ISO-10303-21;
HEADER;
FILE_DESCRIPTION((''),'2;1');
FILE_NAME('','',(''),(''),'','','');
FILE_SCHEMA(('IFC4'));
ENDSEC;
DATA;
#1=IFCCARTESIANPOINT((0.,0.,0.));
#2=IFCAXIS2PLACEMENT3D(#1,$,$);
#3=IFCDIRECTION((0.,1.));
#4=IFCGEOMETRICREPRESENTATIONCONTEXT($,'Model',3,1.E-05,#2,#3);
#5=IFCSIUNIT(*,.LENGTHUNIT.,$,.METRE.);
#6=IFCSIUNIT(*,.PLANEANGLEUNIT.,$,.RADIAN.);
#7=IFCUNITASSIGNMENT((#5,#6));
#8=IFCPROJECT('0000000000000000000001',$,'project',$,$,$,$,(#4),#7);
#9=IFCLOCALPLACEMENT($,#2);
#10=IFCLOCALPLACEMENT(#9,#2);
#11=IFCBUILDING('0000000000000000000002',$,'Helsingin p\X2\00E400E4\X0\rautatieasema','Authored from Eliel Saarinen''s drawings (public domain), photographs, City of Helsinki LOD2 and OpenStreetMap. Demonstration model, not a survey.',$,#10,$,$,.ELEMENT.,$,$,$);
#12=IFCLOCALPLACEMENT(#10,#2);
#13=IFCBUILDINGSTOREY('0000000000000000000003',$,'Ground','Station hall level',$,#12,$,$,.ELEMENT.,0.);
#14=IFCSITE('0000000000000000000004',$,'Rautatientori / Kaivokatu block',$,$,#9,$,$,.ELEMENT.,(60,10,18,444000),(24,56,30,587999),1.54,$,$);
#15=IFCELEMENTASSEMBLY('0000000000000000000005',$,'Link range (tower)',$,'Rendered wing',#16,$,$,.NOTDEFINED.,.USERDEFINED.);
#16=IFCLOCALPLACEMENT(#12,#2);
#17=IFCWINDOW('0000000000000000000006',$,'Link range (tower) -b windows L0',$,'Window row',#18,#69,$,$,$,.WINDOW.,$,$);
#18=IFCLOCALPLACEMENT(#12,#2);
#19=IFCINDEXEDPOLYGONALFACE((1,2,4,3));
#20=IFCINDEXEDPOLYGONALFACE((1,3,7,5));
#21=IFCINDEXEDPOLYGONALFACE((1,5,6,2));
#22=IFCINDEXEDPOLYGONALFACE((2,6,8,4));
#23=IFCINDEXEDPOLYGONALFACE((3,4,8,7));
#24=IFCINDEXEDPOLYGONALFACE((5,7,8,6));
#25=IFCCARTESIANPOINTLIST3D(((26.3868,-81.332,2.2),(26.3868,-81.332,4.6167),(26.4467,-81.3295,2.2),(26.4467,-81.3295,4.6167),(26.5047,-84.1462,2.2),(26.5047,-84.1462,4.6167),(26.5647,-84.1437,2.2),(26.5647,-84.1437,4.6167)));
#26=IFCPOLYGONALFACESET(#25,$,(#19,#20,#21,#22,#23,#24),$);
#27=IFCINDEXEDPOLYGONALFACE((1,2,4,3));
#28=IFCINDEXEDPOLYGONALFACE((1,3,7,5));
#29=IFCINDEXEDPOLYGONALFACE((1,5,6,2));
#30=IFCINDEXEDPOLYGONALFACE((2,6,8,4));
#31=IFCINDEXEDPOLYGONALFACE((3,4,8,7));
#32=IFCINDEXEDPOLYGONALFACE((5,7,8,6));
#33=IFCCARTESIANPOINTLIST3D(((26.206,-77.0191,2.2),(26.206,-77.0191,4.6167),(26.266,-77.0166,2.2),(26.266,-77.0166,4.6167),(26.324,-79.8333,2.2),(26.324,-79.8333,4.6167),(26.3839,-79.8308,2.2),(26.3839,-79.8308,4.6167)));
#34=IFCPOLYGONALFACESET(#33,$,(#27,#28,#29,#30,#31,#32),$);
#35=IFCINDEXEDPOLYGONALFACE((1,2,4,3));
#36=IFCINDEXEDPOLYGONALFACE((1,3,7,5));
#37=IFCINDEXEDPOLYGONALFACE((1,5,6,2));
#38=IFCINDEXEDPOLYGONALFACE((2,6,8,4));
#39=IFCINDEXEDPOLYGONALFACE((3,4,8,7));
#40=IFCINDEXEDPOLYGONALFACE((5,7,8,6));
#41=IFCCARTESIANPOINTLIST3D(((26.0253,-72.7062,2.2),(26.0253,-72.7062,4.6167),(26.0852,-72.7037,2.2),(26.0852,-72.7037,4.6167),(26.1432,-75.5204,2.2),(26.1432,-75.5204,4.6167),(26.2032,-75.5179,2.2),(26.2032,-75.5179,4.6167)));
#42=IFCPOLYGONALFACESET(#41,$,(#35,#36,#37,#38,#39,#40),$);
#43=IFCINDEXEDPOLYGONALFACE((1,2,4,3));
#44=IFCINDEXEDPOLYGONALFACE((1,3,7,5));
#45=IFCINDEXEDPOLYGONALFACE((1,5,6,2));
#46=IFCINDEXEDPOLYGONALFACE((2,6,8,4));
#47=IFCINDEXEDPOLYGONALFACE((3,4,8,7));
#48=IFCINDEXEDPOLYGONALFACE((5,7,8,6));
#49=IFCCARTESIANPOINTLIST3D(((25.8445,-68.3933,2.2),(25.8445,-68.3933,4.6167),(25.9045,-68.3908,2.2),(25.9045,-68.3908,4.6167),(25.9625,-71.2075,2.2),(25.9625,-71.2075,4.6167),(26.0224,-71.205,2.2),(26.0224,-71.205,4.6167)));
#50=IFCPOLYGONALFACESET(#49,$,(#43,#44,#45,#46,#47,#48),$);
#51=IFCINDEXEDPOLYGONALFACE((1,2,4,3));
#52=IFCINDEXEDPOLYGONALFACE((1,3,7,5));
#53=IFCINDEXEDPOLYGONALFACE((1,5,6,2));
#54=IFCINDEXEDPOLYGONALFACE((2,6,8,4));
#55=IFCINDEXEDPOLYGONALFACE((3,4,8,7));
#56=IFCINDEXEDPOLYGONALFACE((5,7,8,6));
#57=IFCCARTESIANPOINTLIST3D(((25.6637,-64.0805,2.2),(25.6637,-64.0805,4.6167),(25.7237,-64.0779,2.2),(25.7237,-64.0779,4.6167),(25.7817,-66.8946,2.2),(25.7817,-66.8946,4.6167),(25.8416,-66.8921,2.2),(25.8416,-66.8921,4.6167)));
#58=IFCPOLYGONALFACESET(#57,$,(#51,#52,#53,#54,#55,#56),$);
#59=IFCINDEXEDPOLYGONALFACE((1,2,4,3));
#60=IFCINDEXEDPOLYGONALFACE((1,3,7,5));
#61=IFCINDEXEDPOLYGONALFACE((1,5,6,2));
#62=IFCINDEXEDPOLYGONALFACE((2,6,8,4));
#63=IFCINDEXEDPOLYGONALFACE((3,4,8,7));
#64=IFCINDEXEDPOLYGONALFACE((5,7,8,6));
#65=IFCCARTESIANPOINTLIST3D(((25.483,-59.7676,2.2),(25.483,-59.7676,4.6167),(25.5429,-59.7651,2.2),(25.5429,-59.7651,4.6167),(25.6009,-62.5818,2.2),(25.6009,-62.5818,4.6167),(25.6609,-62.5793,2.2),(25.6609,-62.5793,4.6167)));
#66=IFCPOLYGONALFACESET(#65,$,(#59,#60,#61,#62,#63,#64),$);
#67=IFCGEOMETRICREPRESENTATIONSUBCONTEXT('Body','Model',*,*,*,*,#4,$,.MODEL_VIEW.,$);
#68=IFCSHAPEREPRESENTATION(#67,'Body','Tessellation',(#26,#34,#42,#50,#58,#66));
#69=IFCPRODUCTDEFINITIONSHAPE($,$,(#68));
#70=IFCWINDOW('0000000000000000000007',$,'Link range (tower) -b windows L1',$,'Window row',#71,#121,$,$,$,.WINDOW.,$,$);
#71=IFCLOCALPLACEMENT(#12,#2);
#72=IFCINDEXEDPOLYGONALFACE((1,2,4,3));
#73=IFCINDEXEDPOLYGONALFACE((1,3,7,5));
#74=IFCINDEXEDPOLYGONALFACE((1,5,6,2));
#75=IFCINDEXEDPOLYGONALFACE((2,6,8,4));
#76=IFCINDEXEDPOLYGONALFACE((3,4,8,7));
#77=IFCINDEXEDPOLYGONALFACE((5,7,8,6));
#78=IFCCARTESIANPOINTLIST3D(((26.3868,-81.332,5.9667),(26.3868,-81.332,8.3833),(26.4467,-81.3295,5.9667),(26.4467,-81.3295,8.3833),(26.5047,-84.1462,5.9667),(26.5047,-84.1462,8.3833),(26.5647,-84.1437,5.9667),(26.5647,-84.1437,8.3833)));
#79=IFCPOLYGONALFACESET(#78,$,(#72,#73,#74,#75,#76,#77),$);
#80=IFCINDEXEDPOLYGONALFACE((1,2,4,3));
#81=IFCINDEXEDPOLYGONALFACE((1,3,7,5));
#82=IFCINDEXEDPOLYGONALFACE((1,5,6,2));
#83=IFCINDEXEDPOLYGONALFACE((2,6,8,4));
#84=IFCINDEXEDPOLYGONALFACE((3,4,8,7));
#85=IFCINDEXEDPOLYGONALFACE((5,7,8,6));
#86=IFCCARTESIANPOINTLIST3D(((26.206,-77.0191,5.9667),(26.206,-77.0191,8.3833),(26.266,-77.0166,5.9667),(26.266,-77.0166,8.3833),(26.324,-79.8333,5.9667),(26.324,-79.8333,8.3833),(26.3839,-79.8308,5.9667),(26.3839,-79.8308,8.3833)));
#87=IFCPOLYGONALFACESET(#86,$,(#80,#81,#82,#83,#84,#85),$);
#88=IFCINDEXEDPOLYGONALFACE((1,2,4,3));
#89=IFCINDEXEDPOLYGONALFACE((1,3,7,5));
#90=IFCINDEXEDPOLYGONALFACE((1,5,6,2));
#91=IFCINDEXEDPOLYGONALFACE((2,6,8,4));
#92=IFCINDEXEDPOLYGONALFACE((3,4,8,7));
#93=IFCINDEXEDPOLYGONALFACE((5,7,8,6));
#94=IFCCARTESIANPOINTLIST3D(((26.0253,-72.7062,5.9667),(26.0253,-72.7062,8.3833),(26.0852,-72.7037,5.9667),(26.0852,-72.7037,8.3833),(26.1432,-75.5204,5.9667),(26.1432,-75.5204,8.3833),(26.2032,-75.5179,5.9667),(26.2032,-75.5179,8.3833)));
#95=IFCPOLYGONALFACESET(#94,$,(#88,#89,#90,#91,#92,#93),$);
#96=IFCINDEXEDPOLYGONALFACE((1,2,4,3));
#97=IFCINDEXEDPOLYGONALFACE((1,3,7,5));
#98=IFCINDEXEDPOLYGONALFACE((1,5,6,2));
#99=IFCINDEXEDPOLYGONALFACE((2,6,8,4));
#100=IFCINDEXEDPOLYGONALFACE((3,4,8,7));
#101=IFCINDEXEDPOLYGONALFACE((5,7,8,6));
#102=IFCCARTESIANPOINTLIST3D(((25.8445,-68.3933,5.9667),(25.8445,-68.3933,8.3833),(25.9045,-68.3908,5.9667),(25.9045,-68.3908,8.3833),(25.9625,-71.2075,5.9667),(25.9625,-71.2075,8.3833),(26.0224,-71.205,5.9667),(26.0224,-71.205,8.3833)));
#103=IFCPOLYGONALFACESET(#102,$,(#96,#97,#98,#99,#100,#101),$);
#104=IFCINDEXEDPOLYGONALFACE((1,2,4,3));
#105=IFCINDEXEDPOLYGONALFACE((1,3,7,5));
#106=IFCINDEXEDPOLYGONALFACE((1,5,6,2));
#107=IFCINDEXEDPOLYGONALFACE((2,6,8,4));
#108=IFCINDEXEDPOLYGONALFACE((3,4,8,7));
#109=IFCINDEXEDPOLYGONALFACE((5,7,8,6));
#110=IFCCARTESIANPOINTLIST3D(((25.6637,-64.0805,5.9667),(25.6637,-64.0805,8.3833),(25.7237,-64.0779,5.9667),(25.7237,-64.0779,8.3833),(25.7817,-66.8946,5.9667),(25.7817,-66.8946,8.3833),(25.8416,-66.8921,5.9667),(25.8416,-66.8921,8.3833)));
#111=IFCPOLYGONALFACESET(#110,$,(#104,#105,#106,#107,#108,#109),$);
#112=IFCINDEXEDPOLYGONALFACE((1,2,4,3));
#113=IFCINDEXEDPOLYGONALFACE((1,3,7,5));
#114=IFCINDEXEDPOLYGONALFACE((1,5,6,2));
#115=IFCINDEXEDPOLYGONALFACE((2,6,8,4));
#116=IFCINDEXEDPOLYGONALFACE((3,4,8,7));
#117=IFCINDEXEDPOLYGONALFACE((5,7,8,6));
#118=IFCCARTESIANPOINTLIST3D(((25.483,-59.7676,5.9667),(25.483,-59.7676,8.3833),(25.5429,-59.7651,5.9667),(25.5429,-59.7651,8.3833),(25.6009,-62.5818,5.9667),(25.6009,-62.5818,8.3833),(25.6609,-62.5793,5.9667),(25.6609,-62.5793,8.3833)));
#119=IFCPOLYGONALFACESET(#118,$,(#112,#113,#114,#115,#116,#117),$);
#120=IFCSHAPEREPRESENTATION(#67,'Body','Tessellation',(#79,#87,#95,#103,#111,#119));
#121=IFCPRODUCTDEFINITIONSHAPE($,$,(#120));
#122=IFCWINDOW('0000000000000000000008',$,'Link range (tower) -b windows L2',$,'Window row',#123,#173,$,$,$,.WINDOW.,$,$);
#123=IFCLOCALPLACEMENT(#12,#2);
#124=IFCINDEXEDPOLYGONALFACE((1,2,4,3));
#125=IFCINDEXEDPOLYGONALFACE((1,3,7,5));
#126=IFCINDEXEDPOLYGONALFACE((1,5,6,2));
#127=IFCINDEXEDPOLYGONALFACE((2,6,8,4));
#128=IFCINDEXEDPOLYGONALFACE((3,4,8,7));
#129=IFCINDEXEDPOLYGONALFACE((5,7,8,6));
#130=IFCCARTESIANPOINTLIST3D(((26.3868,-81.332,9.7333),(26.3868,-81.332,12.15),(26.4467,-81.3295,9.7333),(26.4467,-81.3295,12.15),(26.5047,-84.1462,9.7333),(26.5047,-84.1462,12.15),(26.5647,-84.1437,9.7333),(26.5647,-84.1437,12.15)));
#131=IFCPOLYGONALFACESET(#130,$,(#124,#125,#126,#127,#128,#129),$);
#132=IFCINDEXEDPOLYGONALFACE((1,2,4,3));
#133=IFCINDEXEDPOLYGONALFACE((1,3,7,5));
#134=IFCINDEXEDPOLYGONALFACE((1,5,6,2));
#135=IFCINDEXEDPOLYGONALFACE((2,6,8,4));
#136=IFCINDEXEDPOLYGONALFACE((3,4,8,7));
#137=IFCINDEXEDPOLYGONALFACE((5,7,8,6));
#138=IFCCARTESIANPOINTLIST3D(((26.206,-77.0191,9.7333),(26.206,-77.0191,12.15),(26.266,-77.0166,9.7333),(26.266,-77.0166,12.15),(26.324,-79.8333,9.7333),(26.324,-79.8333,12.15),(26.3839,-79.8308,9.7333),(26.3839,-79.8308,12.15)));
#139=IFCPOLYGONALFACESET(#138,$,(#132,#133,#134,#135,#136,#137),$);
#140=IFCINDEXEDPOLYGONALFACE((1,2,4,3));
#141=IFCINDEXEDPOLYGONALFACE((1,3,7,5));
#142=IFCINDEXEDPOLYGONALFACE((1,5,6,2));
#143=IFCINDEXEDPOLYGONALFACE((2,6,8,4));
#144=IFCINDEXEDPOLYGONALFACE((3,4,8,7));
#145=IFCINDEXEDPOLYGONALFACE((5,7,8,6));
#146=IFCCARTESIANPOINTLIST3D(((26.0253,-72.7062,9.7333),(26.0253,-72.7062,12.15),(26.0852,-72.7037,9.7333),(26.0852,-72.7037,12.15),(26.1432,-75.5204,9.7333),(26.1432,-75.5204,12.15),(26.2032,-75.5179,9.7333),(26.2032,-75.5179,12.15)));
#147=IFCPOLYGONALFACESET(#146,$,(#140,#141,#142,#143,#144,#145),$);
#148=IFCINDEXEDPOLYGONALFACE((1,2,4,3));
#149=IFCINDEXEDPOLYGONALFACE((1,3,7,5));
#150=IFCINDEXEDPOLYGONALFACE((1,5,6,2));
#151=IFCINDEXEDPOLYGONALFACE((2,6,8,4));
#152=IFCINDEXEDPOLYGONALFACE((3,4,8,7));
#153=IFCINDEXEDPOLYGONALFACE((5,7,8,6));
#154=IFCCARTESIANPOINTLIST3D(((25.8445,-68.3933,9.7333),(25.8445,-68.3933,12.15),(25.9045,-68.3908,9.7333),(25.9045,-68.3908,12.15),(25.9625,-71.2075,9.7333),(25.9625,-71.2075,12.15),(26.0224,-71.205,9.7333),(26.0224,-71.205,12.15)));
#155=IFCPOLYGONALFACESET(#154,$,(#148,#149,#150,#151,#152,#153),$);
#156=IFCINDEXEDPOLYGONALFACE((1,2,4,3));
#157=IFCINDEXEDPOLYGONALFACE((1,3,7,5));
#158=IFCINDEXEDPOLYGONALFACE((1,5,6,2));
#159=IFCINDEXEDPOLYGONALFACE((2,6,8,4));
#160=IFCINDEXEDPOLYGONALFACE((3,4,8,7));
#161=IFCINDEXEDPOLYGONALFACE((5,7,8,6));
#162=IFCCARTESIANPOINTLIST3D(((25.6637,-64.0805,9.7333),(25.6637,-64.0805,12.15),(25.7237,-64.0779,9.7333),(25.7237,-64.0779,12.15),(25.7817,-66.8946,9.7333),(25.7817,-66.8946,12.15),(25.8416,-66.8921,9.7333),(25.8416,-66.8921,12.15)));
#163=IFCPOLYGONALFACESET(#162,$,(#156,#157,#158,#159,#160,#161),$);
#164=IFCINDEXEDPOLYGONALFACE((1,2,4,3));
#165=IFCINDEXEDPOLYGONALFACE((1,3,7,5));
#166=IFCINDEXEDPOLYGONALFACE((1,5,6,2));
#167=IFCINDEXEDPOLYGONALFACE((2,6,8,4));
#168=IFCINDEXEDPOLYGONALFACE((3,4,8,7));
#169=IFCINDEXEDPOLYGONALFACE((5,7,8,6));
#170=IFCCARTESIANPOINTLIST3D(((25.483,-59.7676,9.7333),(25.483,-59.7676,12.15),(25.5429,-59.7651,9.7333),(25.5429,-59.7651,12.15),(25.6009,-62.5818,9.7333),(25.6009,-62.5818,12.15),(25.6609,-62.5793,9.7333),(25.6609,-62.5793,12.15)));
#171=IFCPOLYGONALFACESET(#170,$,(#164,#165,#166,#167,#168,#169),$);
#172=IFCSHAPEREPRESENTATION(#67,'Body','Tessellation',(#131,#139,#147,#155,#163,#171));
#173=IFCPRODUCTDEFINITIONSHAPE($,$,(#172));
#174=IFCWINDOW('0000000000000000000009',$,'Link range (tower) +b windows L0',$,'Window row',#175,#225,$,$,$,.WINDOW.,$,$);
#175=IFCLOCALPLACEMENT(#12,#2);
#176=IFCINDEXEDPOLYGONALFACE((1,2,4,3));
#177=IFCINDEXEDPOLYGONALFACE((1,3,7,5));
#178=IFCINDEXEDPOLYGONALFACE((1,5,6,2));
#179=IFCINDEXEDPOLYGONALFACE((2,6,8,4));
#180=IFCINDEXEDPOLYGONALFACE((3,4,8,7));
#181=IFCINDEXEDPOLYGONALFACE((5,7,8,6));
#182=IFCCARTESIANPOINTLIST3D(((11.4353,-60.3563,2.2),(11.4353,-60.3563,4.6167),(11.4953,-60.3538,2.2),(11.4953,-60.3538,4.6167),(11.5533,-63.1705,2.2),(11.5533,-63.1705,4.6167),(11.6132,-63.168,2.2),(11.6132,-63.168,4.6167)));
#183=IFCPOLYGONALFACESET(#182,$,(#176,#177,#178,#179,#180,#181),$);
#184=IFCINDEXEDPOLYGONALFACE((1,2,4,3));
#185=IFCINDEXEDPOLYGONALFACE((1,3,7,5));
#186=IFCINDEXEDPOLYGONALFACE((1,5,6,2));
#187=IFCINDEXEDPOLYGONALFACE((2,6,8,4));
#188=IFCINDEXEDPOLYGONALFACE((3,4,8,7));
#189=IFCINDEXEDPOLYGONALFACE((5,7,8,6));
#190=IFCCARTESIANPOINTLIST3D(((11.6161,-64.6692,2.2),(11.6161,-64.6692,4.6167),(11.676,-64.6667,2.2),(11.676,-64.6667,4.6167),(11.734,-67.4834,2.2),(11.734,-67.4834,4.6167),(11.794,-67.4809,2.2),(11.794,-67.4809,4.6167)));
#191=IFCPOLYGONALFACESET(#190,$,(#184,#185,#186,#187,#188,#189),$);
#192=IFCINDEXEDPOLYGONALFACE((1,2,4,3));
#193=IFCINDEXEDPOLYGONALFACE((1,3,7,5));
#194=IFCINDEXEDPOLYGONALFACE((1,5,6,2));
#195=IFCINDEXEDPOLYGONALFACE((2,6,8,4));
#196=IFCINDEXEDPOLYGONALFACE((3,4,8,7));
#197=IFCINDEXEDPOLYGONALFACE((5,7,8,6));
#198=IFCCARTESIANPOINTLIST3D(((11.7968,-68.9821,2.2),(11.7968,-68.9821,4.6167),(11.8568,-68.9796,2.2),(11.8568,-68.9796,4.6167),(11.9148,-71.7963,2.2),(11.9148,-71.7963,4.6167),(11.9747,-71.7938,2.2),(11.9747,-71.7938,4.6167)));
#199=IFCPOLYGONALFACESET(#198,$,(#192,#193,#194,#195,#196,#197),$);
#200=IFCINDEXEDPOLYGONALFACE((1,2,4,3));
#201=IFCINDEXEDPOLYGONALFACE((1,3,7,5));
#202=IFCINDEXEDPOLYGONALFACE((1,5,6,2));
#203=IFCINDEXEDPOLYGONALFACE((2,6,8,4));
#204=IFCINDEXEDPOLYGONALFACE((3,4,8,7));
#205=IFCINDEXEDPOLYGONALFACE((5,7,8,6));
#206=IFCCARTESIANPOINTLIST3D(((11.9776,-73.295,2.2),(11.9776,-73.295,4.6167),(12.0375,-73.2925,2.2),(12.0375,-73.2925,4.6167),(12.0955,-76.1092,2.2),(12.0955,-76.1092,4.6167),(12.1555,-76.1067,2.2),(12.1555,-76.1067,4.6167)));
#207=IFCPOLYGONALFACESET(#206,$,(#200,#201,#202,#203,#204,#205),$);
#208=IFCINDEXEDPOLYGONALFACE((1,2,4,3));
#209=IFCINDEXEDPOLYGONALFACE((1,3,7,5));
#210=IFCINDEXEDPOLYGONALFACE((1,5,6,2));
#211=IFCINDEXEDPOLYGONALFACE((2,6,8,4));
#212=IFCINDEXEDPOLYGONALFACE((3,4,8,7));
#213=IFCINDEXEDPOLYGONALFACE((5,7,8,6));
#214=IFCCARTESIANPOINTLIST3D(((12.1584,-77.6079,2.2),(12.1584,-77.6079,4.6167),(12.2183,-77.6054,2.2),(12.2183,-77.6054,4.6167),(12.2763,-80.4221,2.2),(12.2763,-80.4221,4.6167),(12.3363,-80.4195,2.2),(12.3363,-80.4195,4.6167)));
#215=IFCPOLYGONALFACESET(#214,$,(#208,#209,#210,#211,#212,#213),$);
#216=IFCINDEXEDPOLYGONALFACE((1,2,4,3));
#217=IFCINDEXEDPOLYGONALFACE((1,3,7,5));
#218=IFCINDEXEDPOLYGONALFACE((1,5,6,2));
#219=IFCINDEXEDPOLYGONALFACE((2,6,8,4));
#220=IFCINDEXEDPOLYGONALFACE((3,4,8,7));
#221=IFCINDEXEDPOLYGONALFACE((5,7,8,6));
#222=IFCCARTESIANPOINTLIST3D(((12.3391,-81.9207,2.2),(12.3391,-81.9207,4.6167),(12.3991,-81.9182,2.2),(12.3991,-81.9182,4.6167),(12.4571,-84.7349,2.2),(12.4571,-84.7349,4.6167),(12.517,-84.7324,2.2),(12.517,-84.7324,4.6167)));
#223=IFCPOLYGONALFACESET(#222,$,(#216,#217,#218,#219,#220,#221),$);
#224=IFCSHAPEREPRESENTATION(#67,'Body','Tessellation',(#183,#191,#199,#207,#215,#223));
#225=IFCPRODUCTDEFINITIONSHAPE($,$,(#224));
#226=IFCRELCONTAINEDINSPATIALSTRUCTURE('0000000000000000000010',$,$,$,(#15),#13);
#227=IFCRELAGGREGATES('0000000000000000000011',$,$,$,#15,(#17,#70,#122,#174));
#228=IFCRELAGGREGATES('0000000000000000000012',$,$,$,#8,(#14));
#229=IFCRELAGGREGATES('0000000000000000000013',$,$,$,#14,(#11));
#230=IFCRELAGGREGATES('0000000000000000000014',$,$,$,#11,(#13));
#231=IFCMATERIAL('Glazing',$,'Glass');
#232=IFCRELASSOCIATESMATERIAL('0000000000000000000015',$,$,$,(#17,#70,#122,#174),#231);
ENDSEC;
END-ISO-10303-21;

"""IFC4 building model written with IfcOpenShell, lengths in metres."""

from ifc_helpers import new_model, si_unit, direction, frame, frame_2d, origin, place, context, subcontext, project, spatial, rectangle, extrude, material, element, aggregate, save


model = new_model("IFC4")

# Units and contexts
model_context = context("Model", 3, precision=1e-05, world=origin(), true_north=direction((0.0, 1.0)))
body_context = subcontext(model_context, "Body", "Model", "MODEL_VIEW")
ifc_project = project(units=[si_unit("LENGTHUNIT", "METRE"), si_unit("PLANEANGLEUNIT", "RADIAN")], contexts=[model_context])

# Site, building, storey
site_placement = place(None, origin())
site = spatial("IfcSite", under=ifc_project, at=site_placement, Name="Rautatientori / Kaivokatu block", CompositionType="ELEMENT", RefLatitude=(60, 10, 18, 444000), RefLongitude=(24, 56, 30, 587999), RefElevation=1.54)
building_placement = place(site_placement, origin())
building = spatial("IfcBuilding", under=site, at=building_placement, Name="Helsingin päärautatieasema", Description="Authored from Eliel Saarinen's drawings (public domain), photographs, City of Helsinki LOD2 and OpenStreetMap. Demonstration model, not a survey.", CompositionType="ELEMENT")
storey_placement = place(building_placement, origin())
storey = spatial("IfcBuildingStorey", under=building, at=storey_placement, Name="Ground", Description="Station hall level", CompositionType="ELEMENT", Elevation=0.0)

# Element assembly
assembly_1_placement = place(building_placement, origin())
assembly_1 = element("IfcElementAssembly", 1, at=assembly_1_placement, inside=storey, Name="Link range (tower)", ObjectType="Rendered wing", AssemblyPlace="NOTDEFINED", PredefinedType="USERDEFINED")

# Shared definitions
ifc_material_1 = material(Name="Glazing", Category="Glass")

# Windows
window_1_placement = place(building_placement, origin())
window_1 = element("IfcWindow", 2, at=window_1_placement, material=ifc_material_1, Name="Link range (tower) -b windows L0", ObjectType="Window row", PredefinedType="WINDOW", context=body_context, shape_type="SweptSolid", body=[
    extrude(rectangle(XDim=2.8167, YDim=0.06, at=frame_2d((0.0, 0.0), x_axis=(-0.041876, 0.999123))), frame((26.4757, -82.7378, 2.2)), (0.0, 0.0, 1.0), 2.4167),
    extrude(rectangle(XDim=2.8167, YDim=0.06, at=frame_2d((0.0, 0.0), x_axis=(-0.041876, 0.999123))), frame((26.295, -78.4249, 2.2)), (0.0, 0.0, 1.0), 2.4167),
    extrude(rectangle(XDim=2.8167, YDim=0.06, at=frame_2d((0.0, 0.0), x_axis=(-0.041876, 0.999123))), frame((26.1142, -74.1121, 2.2)), (0.0, 0.0, 1.0), 2.4167),
    extrude(rectangle(XDim=2.8167, YDim=0.06, at=frame_2d((0.0, 0.0), x_axis=(-0.041876, 0.999123))), frame((25.9335, -69.7992, 2.2)), (0.0, 0.0, 1.0), 2.4167),
    extrude(rectangle(XDim=2.8167, YDim=0.06, at=frame_2d((0.0, 0.0), x_axis=(-0.041876, 0.999123))), frame((25.7527, -65.4863, 2.2)), (0.0, 0.0, 1.0), 2.4167),
    extrude(rectangle(XDim=2.8167, YDim=0.06, at=frame_2d((0.0, 0.0), x_axis=(-0.041876, 0.999123))), frame((25.5719, -61.1734, 2.2)), (0.0, 0.0, 1.0), 2.4167),
])
window_2_placement = place(building_placement, origin())
window_2 = element("IfcWindow", 3, at=window_2_placement, material=ifc_material_1, Name="Link range (tower) -b windows L1", ObjectType="Window row", PredefinedType="WINDOW", context=body_context, shape_type="SweptSolid", body=[
    extrude(rectangle(XDim=2.8167, YDim=0.06, at=frame_2d((0.0, 0.0), x_axis=(-0.041876, 0.999123))), frame((26.4757, -82.7378, 5.9667)), (0.0, 0.0, 1.0), 2.4167),
    extrude(rectangle(XDim=2.8167, YDim=0.06, at=frame_2d((0.0, 0.0), x_axis=(-0.041876, 0.999123))), frame((26.295, -78.4249, 5.9667)), (0.0, 0.0, 1.0), 2.4167),
    extrude(rectangle(XDim=2.8167, YDim=0.06, at=frame_2d((0.0, 0.0), x_axis=(-0.041876, 0.999123))), frame((26.1142, -74.1121, 5.9667)), (0.0, 0.0, 1.0), 2.4167),
    extrude(rectangle(XDim=2.8167, YDim=0.06, at=frame_2d((0.0, 0.0), x_axis=(-0.041876, 0.999123))), frame((25.9335, -69.7992, 5.9667)), (0.0, 0.0, 1.0), 2.4167),
    extrude(rectangle(XDim=2.8167, YDim=0.06, at=frame_2d((0.0, 0.0), x_axis=(-0.041876, 0.999123))), frame((25.7527, -65.4863, 5.9667)), (0.0, 0.0, 1.0), 2.4167),
    extrude(rectangle(XDim=2.8167, YDim=0.06, at=frame_2d((0.0, 0.0), x_axis=(-0.041876, 0.999123))), frame((25.5719, -61.1734, 5.9667)), (0.0, 0.0, 1.0), 2.4167),
])
window_3_placement = place(building_placement, origin())
window_3 = element("IfcWindow", 4, at=window_3_placement, material=ifc_material_1, Name="Link range (tower) -b windows L2", ObjectType="Window row", PredefinedType="WINDOW", context=body_context, shape_type="SweptSolid", body=[
    extrude(rectangle(XDim=2.8167, YDim=0.06, at=frame_2d((0.0, 0.0), x_axis=(-0.041876, 0.999123))), frame((26.4757, -82.7378, 9.7333)), (0.0, 0.0, 1.0), 2.4167),
    extrude(rectangle(XDim=2.8167, YDim=0.06, at=frame_2d((0.0, 0.0), x_axis=(-0.041876, 0.999123))), frame((26.295, -78.4249, 9.7333)), (0.0, 0.0, 1.0), 2.4167),
    extrude(rectangle(XDim=2.8167, YDim=0.06, at=frame_2d((0.0, 0.0), x_axis=(-0.041876, 0.999123))), frame((26.1142, -74.1121, 9.7333)), (0.0, 0.0, 1.0), 2.4167),
    extrude(rectangle(XDim=2.8167, YDim=0.06, at=frame_2d((0.0, 0.0), x_axis=(-0.041876, 0.999123))), frame((25.9335, -69.7992, 9.7333)), (0.0, 0.0, 1.0), 2.4167),
    extrude(rectangle(XDim=2.8167, YDim=0.06, at=frame_2d((0.0, 0.0), x_axis=(-0.041876, 0.999123))), frame((25.7527, -65.4863, 9.7333)), (0.0, 0.0, 1.0), 2.4167),
    extrude(rectangle(XDim=2.8167, YDim=0.06, at=frame_2d((0.0, 0.0), x_axis=(-0.041876, 0.999123))), frame((25.5719, -61.1734, 9.7333)), (0.0, 0.0, 1.0), 2.4167),
])
window_4_placement = place(building_placement, origin())
window_4 = element("IfcWindow", 5, at=window_4_placement, material=ifc_material_1, Name="Link range (tower) +b windows L0", ObjectType="Window row", PredefinedType="WINDOW", context=body_context, shape_type="SweptSolid", body=[
    extrude(rectangle(XDim=2.8167, YDim=0.06, at=frame_2d((0.0, 0.0), x_axis=(0.041876, -0.999123))), frame((11.5243, -61.7622, 2.2)), (0.0, 0.0, 1.0), 2.4167),
    extrude(rectangle(XDim=2.8167, YDim=0.06, at=frame_2d((0.0, 0.0), x_axis=(0.041876, -0.999123))), frame((11.705, -66.0751, 2.2)), (0.0, 0.0, 1.0), 2.4167),
    extrude(rectangle(XDim=2.8167, YDim=0.06, at=frame_2d((0.0, 0.0), x_axis=(0.041876, -0.999123))), frame((11.8858, -70.3879, 2.2)), (0.0, 0.0, 1.0), 2.4167),
    extrude(rectangle(XDim=2.8167, YDim=0.06, at=frame_2d((0.0, 0.0), x_axis=(0.041876, -0.999123))), frame((12.0665, -74.7008, 2.2)), (0.0, 0.0, 1.0), 2.4167),
    extrude(rectangle(XDim=2.8167, YDim=0.06, at=frame_2d((0.0, 0.0), x_axis=(0.041876, -0.999123))), frame((12.2473, -79.0137, 2.2)), (0.0, 0.0, 1.0), 2.4167),
    extrude(rectangle(XDim=2.8167, YDim=0.06, at=frame_2d((0.0, 0.0), x_axis=(0.041876, -0.999123))), frame((12.4281, -83.3266, 2.2)), (0.0, 0.0, 1.0), 2.4167),
])
aggregate(assembly_1, [window_1, window_2, window_3, window_4])

save(model, "model.ifc")
